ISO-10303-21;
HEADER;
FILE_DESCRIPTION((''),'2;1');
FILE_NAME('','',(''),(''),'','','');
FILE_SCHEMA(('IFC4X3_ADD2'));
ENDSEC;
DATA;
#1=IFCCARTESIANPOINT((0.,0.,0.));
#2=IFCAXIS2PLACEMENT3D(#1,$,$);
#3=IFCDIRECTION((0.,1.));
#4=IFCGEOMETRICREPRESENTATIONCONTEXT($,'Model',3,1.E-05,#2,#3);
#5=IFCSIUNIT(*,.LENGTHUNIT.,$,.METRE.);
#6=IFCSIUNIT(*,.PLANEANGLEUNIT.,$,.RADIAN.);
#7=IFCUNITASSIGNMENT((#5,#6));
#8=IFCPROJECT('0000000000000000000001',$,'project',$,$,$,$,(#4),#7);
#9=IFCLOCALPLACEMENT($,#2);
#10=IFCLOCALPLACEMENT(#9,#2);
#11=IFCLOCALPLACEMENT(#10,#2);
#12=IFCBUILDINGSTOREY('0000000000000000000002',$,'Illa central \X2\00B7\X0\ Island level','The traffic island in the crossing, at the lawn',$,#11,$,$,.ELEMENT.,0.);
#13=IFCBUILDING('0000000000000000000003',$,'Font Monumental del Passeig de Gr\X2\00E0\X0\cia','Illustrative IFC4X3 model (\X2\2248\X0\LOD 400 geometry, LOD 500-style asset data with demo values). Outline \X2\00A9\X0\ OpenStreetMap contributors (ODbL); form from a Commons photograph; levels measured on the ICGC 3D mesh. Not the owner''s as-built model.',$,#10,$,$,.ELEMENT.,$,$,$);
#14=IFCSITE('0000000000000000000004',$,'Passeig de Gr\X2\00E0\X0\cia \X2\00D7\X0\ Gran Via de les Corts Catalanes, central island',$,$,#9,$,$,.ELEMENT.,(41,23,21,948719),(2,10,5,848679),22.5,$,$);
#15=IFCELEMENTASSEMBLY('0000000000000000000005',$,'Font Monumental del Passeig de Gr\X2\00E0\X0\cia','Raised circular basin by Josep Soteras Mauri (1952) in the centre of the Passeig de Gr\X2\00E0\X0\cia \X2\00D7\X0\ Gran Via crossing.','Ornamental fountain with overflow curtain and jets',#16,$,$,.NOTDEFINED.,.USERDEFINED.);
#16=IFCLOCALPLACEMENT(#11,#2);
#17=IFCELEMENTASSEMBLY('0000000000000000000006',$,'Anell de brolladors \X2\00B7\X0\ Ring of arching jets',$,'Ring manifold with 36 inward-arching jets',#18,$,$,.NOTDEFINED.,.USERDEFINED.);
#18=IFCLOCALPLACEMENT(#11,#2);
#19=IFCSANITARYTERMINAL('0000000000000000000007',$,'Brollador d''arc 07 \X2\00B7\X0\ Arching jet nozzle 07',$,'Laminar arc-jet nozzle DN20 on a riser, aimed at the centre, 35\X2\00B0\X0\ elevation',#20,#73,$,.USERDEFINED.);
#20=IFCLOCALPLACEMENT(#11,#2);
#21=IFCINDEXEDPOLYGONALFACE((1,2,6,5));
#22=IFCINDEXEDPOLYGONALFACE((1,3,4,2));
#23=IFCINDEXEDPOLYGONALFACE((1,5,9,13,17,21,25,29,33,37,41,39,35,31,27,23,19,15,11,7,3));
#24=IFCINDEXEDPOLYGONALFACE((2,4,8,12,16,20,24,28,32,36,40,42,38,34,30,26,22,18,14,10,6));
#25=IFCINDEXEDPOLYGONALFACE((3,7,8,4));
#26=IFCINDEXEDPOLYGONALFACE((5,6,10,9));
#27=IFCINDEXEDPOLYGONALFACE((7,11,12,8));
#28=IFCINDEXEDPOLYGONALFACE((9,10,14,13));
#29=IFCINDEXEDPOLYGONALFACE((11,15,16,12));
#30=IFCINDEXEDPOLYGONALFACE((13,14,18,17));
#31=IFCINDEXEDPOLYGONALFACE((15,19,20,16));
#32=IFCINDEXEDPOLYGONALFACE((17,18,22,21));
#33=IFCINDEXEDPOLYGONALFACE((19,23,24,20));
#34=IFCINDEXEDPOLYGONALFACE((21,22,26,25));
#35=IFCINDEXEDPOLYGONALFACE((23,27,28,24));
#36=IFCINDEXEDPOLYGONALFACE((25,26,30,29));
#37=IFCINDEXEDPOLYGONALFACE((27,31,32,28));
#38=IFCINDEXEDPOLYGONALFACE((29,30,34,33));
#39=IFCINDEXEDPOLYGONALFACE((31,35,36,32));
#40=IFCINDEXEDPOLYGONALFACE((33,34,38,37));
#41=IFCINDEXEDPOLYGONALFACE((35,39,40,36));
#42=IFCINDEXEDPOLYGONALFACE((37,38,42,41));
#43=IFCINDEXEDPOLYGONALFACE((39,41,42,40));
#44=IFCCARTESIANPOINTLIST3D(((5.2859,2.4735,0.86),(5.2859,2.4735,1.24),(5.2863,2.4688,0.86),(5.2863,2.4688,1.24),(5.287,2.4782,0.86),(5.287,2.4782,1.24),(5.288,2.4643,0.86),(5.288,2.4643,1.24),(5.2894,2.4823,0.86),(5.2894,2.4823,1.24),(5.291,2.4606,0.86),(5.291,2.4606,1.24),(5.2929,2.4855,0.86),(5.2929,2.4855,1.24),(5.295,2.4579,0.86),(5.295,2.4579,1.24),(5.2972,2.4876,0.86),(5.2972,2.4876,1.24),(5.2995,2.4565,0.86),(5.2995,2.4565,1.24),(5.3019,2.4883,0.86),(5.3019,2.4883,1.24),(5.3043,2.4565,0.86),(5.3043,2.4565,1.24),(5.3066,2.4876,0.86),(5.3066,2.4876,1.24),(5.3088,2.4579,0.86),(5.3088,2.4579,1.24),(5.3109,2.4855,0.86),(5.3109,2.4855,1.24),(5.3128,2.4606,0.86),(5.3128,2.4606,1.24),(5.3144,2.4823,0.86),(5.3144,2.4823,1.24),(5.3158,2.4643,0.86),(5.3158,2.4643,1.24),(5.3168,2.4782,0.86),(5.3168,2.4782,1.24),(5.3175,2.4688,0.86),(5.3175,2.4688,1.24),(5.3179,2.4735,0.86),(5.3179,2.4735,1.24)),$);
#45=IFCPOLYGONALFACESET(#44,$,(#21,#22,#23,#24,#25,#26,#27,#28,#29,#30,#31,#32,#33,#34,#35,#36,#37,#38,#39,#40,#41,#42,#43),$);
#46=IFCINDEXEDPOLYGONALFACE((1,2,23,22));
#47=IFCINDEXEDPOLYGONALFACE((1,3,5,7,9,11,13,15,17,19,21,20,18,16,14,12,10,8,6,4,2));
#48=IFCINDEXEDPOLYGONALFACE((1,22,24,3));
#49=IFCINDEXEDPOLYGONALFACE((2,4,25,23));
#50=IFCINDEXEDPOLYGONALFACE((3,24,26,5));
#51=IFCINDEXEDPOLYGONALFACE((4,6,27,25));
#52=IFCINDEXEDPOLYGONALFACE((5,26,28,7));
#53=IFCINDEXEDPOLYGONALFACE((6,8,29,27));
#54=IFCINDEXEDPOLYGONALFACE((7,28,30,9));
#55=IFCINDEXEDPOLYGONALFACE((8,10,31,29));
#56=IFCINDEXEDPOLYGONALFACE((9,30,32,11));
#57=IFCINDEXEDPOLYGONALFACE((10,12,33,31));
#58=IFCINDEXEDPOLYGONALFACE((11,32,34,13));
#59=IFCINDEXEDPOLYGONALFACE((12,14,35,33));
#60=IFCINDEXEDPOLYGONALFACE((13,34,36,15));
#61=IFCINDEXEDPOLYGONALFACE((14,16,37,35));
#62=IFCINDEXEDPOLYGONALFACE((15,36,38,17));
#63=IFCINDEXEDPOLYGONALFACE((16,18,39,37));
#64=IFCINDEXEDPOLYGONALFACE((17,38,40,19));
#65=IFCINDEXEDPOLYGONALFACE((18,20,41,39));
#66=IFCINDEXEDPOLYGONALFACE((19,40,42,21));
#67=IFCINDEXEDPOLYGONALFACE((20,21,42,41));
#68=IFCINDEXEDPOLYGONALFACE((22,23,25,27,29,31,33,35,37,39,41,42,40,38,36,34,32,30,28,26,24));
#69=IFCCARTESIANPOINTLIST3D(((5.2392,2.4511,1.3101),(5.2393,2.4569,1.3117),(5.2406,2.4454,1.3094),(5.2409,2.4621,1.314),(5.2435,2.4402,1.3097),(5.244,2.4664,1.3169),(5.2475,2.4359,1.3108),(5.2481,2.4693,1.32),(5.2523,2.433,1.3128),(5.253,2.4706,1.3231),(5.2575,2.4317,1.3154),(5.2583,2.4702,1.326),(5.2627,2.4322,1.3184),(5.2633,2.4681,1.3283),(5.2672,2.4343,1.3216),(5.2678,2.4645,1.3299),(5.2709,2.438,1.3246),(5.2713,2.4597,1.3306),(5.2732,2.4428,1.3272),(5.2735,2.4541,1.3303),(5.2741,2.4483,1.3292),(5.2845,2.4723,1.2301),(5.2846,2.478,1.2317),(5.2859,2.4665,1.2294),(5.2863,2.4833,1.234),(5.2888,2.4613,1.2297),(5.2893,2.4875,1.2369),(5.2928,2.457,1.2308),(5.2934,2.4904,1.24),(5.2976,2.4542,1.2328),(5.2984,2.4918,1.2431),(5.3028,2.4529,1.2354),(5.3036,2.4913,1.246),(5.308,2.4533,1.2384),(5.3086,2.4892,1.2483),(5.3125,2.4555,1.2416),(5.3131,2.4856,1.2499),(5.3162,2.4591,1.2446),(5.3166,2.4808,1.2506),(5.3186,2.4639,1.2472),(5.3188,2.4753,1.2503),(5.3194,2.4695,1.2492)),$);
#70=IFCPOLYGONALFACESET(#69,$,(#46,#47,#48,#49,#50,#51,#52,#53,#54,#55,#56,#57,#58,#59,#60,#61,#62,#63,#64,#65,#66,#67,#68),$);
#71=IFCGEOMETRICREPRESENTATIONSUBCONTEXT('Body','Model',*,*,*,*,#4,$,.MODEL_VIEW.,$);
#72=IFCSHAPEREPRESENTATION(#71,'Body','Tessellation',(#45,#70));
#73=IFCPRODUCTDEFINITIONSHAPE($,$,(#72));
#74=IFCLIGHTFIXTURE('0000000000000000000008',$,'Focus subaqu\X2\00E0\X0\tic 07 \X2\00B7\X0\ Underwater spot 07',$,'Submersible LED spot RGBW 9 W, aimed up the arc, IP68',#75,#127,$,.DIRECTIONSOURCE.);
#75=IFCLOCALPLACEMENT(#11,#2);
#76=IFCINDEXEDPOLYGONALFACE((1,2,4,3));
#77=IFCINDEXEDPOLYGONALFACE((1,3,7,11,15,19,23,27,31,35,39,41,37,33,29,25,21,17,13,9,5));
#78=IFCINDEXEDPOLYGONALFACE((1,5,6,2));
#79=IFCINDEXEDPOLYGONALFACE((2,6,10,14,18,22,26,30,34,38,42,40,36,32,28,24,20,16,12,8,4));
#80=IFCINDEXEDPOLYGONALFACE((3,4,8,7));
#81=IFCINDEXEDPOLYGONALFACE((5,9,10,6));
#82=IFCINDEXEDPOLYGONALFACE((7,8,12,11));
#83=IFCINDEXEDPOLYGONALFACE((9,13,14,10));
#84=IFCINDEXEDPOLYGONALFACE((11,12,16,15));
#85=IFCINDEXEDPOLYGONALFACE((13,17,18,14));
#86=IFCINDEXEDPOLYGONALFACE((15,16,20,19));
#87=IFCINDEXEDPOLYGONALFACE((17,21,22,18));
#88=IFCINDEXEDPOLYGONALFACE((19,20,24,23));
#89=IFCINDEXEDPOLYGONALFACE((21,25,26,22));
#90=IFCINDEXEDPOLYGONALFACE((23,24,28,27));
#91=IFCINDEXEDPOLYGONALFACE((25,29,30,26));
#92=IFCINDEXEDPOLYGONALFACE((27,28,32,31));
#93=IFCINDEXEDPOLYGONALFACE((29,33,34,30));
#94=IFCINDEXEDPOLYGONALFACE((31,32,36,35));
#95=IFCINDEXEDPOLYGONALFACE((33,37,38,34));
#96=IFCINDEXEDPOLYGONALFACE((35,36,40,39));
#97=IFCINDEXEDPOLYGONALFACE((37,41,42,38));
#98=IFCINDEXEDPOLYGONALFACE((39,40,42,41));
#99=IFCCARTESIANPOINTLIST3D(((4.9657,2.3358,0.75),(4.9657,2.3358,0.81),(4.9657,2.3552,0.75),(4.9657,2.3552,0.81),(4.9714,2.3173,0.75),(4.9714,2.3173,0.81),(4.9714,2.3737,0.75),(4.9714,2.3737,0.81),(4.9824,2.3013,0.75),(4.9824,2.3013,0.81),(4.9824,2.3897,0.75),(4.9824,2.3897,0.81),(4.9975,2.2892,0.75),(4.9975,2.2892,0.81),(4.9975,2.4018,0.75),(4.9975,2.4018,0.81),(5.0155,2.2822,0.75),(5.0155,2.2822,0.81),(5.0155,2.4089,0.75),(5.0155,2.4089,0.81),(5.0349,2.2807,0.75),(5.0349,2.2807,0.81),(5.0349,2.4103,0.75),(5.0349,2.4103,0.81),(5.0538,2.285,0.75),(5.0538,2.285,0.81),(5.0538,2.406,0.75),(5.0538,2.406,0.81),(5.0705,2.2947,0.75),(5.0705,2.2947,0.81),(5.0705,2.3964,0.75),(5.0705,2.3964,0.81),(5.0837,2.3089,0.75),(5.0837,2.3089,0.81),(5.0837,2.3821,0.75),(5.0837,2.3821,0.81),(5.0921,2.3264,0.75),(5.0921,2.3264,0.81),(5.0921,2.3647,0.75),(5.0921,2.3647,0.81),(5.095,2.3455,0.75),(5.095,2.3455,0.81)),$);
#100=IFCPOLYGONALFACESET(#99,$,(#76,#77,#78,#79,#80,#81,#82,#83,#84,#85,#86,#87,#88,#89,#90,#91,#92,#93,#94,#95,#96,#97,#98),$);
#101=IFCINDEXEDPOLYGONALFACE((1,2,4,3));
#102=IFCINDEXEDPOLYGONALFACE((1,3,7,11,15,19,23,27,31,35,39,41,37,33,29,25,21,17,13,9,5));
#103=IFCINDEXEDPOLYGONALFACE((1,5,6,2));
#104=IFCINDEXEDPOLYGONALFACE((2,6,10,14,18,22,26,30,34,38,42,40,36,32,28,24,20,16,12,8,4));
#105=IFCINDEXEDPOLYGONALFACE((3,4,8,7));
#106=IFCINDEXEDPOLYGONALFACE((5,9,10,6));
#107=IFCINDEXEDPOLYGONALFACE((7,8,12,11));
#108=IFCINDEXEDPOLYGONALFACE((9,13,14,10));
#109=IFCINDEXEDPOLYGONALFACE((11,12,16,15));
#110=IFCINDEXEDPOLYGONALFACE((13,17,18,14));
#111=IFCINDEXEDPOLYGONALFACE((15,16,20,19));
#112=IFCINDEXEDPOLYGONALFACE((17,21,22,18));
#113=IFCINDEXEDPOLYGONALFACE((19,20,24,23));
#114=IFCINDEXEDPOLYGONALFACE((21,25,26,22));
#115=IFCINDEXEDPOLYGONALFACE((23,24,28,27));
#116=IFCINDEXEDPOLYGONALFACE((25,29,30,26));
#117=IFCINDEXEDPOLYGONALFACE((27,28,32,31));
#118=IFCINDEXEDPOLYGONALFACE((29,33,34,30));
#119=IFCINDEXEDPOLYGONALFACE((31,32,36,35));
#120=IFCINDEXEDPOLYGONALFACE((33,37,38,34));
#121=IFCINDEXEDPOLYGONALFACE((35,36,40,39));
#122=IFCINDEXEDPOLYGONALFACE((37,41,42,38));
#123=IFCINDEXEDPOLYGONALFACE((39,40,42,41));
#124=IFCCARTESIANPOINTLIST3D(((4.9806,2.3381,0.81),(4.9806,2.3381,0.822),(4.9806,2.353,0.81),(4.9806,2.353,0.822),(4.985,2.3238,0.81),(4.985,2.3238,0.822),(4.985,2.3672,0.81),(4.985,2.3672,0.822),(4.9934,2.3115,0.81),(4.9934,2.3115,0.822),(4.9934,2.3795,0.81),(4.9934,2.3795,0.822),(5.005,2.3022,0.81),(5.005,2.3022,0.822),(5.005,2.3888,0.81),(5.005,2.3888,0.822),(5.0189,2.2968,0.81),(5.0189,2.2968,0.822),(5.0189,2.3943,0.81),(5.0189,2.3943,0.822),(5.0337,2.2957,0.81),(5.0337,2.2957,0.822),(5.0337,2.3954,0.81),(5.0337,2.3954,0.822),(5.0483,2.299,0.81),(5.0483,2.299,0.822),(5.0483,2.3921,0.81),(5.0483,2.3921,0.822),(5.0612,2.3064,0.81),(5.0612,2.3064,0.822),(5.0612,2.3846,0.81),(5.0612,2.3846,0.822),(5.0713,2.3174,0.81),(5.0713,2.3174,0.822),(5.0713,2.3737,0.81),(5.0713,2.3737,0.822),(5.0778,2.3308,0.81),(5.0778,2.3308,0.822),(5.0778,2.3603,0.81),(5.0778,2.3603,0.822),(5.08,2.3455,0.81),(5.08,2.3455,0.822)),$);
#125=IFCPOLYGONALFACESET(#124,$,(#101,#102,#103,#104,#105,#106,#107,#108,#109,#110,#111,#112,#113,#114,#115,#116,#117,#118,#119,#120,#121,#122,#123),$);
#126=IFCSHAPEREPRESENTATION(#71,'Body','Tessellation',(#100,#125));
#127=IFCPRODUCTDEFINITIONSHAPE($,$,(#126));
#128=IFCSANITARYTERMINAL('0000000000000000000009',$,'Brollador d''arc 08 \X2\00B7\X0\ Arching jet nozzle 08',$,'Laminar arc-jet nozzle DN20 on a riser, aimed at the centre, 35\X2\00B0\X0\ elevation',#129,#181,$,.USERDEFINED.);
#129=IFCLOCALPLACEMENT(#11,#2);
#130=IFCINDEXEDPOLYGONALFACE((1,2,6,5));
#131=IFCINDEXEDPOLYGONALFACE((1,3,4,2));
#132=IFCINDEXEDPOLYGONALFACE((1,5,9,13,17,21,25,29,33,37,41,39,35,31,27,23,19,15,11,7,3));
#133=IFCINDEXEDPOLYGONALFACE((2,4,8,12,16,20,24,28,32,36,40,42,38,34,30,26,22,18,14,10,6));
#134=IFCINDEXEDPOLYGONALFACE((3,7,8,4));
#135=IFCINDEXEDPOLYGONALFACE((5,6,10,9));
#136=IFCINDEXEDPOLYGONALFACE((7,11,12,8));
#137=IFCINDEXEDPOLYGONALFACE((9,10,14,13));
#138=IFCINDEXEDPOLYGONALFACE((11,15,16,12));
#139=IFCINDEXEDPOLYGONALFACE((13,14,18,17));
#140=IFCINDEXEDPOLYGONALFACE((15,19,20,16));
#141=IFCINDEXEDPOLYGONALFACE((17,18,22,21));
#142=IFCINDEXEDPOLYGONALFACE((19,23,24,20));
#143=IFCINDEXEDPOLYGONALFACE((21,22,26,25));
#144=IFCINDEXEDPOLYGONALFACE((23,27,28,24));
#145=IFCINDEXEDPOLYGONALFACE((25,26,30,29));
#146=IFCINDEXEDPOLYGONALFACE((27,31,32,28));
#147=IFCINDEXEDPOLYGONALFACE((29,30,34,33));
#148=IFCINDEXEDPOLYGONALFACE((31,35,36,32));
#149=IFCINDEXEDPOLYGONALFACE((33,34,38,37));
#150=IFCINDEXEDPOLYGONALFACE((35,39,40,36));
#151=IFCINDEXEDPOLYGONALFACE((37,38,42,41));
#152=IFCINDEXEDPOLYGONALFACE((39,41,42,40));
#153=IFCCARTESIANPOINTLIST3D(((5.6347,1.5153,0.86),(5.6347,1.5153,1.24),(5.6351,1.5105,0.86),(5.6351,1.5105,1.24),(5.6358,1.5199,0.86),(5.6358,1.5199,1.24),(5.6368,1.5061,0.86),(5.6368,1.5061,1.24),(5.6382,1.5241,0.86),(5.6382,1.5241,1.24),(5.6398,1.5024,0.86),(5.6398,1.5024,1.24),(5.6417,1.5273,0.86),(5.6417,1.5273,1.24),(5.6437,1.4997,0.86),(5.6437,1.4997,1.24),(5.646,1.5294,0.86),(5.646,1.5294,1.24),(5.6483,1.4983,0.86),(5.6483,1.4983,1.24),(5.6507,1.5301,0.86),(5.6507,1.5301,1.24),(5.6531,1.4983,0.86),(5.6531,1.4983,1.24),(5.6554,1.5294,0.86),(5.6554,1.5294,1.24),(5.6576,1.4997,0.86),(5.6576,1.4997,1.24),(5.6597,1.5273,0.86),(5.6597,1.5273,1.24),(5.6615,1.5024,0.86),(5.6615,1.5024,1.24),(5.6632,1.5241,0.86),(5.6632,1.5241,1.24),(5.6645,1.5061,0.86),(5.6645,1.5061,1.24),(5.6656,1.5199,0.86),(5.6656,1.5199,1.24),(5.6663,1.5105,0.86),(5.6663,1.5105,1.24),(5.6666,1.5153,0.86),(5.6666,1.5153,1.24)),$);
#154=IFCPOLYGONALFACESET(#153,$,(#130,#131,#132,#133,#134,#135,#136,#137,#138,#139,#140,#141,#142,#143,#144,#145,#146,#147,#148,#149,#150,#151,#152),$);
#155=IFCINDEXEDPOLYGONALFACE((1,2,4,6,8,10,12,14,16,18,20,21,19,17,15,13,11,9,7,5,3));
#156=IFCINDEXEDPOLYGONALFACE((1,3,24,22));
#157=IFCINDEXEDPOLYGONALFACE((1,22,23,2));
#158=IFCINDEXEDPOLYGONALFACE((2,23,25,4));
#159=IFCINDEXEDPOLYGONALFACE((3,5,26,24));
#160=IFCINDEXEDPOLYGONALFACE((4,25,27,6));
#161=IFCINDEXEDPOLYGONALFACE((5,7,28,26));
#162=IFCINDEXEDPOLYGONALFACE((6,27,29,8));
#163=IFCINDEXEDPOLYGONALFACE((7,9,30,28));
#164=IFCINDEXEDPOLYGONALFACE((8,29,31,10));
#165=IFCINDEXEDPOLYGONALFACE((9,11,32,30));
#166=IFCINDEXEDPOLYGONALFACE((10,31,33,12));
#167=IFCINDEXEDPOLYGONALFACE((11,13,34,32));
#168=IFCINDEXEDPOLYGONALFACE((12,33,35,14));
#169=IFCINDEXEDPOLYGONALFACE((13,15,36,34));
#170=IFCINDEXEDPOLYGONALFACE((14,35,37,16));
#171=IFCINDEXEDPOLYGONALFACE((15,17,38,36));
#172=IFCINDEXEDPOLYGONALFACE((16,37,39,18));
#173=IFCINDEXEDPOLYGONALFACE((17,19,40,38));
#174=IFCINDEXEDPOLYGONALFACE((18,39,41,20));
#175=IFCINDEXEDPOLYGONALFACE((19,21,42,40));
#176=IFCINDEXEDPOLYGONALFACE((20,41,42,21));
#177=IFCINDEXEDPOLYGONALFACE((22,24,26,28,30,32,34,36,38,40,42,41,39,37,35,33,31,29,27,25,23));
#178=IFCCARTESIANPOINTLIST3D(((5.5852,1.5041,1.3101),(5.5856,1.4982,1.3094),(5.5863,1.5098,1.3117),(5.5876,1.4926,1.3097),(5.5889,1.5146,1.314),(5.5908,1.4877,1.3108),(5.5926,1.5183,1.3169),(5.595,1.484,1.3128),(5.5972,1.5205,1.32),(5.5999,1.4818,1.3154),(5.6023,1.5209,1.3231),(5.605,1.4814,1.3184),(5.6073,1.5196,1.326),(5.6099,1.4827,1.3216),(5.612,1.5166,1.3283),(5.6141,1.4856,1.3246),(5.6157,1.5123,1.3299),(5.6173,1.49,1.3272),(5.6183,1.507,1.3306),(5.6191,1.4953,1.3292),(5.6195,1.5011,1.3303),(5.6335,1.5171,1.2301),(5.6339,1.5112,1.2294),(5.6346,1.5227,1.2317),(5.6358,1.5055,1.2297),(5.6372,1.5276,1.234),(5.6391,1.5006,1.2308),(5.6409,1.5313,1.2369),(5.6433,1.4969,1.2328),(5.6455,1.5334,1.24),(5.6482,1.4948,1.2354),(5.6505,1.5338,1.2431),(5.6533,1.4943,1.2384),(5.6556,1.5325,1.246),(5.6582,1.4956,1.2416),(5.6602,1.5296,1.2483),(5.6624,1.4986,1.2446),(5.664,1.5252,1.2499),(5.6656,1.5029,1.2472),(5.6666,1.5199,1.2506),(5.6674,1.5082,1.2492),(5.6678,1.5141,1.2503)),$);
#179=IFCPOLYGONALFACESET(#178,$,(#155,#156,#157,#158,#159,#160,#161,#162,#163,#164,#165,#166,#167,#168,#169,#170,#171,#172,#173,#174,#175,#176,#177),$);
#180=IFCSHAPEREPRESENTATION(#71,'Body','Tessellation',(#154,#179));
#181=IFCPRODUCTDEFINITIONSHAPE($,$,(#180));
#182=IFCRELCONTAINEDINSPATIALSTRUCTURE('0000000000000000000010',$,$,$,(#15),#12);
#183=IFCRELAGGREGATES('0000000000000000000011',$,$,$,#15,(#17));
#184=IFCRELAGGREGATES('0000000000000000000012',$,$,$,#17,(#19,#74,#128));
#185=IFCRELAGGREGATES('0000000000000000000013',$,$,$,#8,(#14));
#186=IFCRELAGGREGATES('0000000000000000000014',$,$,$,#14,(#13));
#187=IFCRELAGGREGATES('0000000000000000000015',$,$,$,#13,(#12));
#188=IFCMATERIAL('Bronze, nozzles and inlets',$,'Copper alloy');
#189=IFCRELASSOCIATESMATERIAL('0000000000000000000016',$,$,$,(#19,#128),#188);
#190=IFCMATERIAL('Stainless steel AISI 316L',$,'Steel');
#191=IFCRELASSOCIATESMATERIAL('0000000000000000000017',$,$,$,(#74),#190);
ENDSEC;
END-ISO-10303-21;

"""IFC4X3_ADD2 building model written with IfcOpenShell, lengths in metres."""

from ifc_helpers import new_model, si_unit, direction, frame, origin, origin_2d_with_axis, place, context, subcontext, project, spatial, circle, extrude, material, element, aggregate, save


model = new_model("IFC4X3_ADD2")

# Units and contexts
model_context = context("Model", 3, precision=1e-05, world=origin(), true_north=direction((0.0, 1.0)))
body_context = subcontext(model_context, "Body", "Model", "MODEL_VIEW")
ifc_project = project(units=[si_unit("LENGTHUNIT", "METRE"), si_unit("PLANEANGLEUNIT", "RADIAN")], contexts=[model_context])

# Site, building, storey
site_placement = place(None, origin())
site = spatial("IfcSite", under=ifc_project, at=site_placement, Name="Passeig de Gràcia × Gran Via de les Corts Catalanes, central island", CompositionType="ELEMENT", RefLatitude=(41, 23, 21, 948719), RefLongitude=(2, 10, 5, 848679), RefElevation=22.5)
building_placement = place(site_placement, origin())
building = spatial("IfcBuilding", under=site, at=building_placement, Name="Font Monumental del Passeig de Gràcia", Description="Illustrative IFC4X3 model (≈LOD 400 geometry, LOD 500-style asset data with demo values). Outline © OpenStreetMap contributors (ODbL); form from a Commons photograph; levels measured on the ICGC 3D mesh. Not the owner's as-built model.", CompositionType="ELEMENT")
storey_placement = place(building_placement, origin())
storey = spatial("IfcBuildingStorey", under=building, at=storey_placement, Name="Illa central · Island level", Description="The traffic island in the crossing, at the lawn", CompositionType="ELEMENT", Elevation=0.0)

# Element assemblies, sanitary terminals, light fixture
assembly_1_placement = place(building_placement, origin())
assembly_1 = element("IfcElementAssembly", 1, at=assembly_1_placement, inside=storey, Name="Font Monumental del Passeig de Gràcia", Description="Raised circular basin by Josep Soteras Mauri (1952) in the centre of the Passeig de Gràcia × Gran Via crossing.", ObjectType="Ornamental fountain with overflow curtain and jets", AssemblyPlace="NOTDEFINED", PredefinedType="USERDEFINED")
assembly_2_placement = place(building_placement, origin())
assembly_2 = element("IfcElementAssembly", 2, at=assembly_2_placement, Name="Anell de brolladors · Ring of arching jets", ObjectType="Ring manifold with 36 inward-arching jets", AssemblyPlace="NOTDEFINED", PredefinedType="USERDEFINED")
aggregate(assembly_1, [assembly_2])
ifc_material_1 = material(Name="Bronze, nozzles and inlets", Category="Copper alloy")
sanitary_terminal_1_placement = place(building_placement, origin())
sanitary_terminal_1 = element("IfcSanitaryTerminal", 3, at=sanitary_terminal_1_placement, material=ifc_material_1, Name="Brollador d'arc 07 · Arching jet nozzle 07", ObjectType="Laminar arc-jet nozzle DN20 on a riser, aimed at the centre, 35° elevation", PredefinedType="USERDEFINED", context=body_context, shape_type="SweptSolid", body=[
    extrude(circle(Radius=0.016, at=origin_2d_with_axis()), frame((5.3019, 2.4723, 0.86), z_axis=(0.0, 0.0, 1.0), x_axis=(0.0, 1.0, 0.0)), (0.0, 0.0, 1.0), 0.38),
    extrude(circle(Radius=0.02, at=origin_2d_with_axis()), frame((5.3019, 2.4723, 1.24), z_axis=(-0.480342, -0.223987, 0.847998), x_axis=(-0.422618, 0.906308, 0.0)), (0.0, 0.0, 1.0), 0.0943),
])
ifc_material_2 = material(Name="Stainless steel AISI 316L", Category="Steel")
light_fixture_1_placement = place(building_placement, origin())
light_fixture_1 = element("IfcLightFixture", 4, at=light_fixture_1_placement, material=ifc_material_2, Name="Focus subaquàtic 07 · Underwater spot 07", ObjectType="Submersible LED spot RGBW 9 W, aimed up the arc, IP68", PredefinedType="DIRECTIONSOURCE", context=body_context, shape_type="SweptSolid", body=[
    extrude(circle(Radius=0.065, at=origin_2d_with_axis()), frame((5.03, 2.3455, 0.75)), (0.0, 0.0, 1.0), 0.06),
    extrude(circle(Radius=0.05, at=origin_2d_with_axis()), frame((5.03, 2.3455, 0.81)), (0.0, 0.0, 1.0), 0.012),
])
sanitary_terminal_2_placement = place(building_placement, origin())
sanitary_terminal_2 = element("IfcSanitaryTerminal", 5, at=sanitary_terminal_2_placement, material=ifc_material_1, Name="Brollador d'arc 08 · Arching jet nozzle 08", ObjectType="Laminar arc-jet nozzle DN20 on a riser, aimed at the centre, 35° elevation", PredefinedType="USERDEFINED", context=body_context, shape_type="SweptSolid", body=[
    extrude(circle(Radius=0.016, at=origin_2d_with_axis()), frame((5.6507, 1.5141, 0.86), z_axis=(0.0, 0.0, 1.0), x_axis=(0.0, 1.0, 0.0)), (0.0, 0.0, 1.0), 0.38),
    extrude(circle(Radius=0.02, at=origin_2d_with_axis()), frame((5.6507, 1.5141, 1.24), z_axis=(-0.51194, -0.137174, 0.847998), x_axis=(-0.258819, 0.965926, 0.0)), (0.0, 0.0, 1.0), 0.0943),
])
aggregate(assembly_2, [sanitary_terminal_1, light_fixture_1, sanitary_terminal_2])

save(model, "model.ifc")
